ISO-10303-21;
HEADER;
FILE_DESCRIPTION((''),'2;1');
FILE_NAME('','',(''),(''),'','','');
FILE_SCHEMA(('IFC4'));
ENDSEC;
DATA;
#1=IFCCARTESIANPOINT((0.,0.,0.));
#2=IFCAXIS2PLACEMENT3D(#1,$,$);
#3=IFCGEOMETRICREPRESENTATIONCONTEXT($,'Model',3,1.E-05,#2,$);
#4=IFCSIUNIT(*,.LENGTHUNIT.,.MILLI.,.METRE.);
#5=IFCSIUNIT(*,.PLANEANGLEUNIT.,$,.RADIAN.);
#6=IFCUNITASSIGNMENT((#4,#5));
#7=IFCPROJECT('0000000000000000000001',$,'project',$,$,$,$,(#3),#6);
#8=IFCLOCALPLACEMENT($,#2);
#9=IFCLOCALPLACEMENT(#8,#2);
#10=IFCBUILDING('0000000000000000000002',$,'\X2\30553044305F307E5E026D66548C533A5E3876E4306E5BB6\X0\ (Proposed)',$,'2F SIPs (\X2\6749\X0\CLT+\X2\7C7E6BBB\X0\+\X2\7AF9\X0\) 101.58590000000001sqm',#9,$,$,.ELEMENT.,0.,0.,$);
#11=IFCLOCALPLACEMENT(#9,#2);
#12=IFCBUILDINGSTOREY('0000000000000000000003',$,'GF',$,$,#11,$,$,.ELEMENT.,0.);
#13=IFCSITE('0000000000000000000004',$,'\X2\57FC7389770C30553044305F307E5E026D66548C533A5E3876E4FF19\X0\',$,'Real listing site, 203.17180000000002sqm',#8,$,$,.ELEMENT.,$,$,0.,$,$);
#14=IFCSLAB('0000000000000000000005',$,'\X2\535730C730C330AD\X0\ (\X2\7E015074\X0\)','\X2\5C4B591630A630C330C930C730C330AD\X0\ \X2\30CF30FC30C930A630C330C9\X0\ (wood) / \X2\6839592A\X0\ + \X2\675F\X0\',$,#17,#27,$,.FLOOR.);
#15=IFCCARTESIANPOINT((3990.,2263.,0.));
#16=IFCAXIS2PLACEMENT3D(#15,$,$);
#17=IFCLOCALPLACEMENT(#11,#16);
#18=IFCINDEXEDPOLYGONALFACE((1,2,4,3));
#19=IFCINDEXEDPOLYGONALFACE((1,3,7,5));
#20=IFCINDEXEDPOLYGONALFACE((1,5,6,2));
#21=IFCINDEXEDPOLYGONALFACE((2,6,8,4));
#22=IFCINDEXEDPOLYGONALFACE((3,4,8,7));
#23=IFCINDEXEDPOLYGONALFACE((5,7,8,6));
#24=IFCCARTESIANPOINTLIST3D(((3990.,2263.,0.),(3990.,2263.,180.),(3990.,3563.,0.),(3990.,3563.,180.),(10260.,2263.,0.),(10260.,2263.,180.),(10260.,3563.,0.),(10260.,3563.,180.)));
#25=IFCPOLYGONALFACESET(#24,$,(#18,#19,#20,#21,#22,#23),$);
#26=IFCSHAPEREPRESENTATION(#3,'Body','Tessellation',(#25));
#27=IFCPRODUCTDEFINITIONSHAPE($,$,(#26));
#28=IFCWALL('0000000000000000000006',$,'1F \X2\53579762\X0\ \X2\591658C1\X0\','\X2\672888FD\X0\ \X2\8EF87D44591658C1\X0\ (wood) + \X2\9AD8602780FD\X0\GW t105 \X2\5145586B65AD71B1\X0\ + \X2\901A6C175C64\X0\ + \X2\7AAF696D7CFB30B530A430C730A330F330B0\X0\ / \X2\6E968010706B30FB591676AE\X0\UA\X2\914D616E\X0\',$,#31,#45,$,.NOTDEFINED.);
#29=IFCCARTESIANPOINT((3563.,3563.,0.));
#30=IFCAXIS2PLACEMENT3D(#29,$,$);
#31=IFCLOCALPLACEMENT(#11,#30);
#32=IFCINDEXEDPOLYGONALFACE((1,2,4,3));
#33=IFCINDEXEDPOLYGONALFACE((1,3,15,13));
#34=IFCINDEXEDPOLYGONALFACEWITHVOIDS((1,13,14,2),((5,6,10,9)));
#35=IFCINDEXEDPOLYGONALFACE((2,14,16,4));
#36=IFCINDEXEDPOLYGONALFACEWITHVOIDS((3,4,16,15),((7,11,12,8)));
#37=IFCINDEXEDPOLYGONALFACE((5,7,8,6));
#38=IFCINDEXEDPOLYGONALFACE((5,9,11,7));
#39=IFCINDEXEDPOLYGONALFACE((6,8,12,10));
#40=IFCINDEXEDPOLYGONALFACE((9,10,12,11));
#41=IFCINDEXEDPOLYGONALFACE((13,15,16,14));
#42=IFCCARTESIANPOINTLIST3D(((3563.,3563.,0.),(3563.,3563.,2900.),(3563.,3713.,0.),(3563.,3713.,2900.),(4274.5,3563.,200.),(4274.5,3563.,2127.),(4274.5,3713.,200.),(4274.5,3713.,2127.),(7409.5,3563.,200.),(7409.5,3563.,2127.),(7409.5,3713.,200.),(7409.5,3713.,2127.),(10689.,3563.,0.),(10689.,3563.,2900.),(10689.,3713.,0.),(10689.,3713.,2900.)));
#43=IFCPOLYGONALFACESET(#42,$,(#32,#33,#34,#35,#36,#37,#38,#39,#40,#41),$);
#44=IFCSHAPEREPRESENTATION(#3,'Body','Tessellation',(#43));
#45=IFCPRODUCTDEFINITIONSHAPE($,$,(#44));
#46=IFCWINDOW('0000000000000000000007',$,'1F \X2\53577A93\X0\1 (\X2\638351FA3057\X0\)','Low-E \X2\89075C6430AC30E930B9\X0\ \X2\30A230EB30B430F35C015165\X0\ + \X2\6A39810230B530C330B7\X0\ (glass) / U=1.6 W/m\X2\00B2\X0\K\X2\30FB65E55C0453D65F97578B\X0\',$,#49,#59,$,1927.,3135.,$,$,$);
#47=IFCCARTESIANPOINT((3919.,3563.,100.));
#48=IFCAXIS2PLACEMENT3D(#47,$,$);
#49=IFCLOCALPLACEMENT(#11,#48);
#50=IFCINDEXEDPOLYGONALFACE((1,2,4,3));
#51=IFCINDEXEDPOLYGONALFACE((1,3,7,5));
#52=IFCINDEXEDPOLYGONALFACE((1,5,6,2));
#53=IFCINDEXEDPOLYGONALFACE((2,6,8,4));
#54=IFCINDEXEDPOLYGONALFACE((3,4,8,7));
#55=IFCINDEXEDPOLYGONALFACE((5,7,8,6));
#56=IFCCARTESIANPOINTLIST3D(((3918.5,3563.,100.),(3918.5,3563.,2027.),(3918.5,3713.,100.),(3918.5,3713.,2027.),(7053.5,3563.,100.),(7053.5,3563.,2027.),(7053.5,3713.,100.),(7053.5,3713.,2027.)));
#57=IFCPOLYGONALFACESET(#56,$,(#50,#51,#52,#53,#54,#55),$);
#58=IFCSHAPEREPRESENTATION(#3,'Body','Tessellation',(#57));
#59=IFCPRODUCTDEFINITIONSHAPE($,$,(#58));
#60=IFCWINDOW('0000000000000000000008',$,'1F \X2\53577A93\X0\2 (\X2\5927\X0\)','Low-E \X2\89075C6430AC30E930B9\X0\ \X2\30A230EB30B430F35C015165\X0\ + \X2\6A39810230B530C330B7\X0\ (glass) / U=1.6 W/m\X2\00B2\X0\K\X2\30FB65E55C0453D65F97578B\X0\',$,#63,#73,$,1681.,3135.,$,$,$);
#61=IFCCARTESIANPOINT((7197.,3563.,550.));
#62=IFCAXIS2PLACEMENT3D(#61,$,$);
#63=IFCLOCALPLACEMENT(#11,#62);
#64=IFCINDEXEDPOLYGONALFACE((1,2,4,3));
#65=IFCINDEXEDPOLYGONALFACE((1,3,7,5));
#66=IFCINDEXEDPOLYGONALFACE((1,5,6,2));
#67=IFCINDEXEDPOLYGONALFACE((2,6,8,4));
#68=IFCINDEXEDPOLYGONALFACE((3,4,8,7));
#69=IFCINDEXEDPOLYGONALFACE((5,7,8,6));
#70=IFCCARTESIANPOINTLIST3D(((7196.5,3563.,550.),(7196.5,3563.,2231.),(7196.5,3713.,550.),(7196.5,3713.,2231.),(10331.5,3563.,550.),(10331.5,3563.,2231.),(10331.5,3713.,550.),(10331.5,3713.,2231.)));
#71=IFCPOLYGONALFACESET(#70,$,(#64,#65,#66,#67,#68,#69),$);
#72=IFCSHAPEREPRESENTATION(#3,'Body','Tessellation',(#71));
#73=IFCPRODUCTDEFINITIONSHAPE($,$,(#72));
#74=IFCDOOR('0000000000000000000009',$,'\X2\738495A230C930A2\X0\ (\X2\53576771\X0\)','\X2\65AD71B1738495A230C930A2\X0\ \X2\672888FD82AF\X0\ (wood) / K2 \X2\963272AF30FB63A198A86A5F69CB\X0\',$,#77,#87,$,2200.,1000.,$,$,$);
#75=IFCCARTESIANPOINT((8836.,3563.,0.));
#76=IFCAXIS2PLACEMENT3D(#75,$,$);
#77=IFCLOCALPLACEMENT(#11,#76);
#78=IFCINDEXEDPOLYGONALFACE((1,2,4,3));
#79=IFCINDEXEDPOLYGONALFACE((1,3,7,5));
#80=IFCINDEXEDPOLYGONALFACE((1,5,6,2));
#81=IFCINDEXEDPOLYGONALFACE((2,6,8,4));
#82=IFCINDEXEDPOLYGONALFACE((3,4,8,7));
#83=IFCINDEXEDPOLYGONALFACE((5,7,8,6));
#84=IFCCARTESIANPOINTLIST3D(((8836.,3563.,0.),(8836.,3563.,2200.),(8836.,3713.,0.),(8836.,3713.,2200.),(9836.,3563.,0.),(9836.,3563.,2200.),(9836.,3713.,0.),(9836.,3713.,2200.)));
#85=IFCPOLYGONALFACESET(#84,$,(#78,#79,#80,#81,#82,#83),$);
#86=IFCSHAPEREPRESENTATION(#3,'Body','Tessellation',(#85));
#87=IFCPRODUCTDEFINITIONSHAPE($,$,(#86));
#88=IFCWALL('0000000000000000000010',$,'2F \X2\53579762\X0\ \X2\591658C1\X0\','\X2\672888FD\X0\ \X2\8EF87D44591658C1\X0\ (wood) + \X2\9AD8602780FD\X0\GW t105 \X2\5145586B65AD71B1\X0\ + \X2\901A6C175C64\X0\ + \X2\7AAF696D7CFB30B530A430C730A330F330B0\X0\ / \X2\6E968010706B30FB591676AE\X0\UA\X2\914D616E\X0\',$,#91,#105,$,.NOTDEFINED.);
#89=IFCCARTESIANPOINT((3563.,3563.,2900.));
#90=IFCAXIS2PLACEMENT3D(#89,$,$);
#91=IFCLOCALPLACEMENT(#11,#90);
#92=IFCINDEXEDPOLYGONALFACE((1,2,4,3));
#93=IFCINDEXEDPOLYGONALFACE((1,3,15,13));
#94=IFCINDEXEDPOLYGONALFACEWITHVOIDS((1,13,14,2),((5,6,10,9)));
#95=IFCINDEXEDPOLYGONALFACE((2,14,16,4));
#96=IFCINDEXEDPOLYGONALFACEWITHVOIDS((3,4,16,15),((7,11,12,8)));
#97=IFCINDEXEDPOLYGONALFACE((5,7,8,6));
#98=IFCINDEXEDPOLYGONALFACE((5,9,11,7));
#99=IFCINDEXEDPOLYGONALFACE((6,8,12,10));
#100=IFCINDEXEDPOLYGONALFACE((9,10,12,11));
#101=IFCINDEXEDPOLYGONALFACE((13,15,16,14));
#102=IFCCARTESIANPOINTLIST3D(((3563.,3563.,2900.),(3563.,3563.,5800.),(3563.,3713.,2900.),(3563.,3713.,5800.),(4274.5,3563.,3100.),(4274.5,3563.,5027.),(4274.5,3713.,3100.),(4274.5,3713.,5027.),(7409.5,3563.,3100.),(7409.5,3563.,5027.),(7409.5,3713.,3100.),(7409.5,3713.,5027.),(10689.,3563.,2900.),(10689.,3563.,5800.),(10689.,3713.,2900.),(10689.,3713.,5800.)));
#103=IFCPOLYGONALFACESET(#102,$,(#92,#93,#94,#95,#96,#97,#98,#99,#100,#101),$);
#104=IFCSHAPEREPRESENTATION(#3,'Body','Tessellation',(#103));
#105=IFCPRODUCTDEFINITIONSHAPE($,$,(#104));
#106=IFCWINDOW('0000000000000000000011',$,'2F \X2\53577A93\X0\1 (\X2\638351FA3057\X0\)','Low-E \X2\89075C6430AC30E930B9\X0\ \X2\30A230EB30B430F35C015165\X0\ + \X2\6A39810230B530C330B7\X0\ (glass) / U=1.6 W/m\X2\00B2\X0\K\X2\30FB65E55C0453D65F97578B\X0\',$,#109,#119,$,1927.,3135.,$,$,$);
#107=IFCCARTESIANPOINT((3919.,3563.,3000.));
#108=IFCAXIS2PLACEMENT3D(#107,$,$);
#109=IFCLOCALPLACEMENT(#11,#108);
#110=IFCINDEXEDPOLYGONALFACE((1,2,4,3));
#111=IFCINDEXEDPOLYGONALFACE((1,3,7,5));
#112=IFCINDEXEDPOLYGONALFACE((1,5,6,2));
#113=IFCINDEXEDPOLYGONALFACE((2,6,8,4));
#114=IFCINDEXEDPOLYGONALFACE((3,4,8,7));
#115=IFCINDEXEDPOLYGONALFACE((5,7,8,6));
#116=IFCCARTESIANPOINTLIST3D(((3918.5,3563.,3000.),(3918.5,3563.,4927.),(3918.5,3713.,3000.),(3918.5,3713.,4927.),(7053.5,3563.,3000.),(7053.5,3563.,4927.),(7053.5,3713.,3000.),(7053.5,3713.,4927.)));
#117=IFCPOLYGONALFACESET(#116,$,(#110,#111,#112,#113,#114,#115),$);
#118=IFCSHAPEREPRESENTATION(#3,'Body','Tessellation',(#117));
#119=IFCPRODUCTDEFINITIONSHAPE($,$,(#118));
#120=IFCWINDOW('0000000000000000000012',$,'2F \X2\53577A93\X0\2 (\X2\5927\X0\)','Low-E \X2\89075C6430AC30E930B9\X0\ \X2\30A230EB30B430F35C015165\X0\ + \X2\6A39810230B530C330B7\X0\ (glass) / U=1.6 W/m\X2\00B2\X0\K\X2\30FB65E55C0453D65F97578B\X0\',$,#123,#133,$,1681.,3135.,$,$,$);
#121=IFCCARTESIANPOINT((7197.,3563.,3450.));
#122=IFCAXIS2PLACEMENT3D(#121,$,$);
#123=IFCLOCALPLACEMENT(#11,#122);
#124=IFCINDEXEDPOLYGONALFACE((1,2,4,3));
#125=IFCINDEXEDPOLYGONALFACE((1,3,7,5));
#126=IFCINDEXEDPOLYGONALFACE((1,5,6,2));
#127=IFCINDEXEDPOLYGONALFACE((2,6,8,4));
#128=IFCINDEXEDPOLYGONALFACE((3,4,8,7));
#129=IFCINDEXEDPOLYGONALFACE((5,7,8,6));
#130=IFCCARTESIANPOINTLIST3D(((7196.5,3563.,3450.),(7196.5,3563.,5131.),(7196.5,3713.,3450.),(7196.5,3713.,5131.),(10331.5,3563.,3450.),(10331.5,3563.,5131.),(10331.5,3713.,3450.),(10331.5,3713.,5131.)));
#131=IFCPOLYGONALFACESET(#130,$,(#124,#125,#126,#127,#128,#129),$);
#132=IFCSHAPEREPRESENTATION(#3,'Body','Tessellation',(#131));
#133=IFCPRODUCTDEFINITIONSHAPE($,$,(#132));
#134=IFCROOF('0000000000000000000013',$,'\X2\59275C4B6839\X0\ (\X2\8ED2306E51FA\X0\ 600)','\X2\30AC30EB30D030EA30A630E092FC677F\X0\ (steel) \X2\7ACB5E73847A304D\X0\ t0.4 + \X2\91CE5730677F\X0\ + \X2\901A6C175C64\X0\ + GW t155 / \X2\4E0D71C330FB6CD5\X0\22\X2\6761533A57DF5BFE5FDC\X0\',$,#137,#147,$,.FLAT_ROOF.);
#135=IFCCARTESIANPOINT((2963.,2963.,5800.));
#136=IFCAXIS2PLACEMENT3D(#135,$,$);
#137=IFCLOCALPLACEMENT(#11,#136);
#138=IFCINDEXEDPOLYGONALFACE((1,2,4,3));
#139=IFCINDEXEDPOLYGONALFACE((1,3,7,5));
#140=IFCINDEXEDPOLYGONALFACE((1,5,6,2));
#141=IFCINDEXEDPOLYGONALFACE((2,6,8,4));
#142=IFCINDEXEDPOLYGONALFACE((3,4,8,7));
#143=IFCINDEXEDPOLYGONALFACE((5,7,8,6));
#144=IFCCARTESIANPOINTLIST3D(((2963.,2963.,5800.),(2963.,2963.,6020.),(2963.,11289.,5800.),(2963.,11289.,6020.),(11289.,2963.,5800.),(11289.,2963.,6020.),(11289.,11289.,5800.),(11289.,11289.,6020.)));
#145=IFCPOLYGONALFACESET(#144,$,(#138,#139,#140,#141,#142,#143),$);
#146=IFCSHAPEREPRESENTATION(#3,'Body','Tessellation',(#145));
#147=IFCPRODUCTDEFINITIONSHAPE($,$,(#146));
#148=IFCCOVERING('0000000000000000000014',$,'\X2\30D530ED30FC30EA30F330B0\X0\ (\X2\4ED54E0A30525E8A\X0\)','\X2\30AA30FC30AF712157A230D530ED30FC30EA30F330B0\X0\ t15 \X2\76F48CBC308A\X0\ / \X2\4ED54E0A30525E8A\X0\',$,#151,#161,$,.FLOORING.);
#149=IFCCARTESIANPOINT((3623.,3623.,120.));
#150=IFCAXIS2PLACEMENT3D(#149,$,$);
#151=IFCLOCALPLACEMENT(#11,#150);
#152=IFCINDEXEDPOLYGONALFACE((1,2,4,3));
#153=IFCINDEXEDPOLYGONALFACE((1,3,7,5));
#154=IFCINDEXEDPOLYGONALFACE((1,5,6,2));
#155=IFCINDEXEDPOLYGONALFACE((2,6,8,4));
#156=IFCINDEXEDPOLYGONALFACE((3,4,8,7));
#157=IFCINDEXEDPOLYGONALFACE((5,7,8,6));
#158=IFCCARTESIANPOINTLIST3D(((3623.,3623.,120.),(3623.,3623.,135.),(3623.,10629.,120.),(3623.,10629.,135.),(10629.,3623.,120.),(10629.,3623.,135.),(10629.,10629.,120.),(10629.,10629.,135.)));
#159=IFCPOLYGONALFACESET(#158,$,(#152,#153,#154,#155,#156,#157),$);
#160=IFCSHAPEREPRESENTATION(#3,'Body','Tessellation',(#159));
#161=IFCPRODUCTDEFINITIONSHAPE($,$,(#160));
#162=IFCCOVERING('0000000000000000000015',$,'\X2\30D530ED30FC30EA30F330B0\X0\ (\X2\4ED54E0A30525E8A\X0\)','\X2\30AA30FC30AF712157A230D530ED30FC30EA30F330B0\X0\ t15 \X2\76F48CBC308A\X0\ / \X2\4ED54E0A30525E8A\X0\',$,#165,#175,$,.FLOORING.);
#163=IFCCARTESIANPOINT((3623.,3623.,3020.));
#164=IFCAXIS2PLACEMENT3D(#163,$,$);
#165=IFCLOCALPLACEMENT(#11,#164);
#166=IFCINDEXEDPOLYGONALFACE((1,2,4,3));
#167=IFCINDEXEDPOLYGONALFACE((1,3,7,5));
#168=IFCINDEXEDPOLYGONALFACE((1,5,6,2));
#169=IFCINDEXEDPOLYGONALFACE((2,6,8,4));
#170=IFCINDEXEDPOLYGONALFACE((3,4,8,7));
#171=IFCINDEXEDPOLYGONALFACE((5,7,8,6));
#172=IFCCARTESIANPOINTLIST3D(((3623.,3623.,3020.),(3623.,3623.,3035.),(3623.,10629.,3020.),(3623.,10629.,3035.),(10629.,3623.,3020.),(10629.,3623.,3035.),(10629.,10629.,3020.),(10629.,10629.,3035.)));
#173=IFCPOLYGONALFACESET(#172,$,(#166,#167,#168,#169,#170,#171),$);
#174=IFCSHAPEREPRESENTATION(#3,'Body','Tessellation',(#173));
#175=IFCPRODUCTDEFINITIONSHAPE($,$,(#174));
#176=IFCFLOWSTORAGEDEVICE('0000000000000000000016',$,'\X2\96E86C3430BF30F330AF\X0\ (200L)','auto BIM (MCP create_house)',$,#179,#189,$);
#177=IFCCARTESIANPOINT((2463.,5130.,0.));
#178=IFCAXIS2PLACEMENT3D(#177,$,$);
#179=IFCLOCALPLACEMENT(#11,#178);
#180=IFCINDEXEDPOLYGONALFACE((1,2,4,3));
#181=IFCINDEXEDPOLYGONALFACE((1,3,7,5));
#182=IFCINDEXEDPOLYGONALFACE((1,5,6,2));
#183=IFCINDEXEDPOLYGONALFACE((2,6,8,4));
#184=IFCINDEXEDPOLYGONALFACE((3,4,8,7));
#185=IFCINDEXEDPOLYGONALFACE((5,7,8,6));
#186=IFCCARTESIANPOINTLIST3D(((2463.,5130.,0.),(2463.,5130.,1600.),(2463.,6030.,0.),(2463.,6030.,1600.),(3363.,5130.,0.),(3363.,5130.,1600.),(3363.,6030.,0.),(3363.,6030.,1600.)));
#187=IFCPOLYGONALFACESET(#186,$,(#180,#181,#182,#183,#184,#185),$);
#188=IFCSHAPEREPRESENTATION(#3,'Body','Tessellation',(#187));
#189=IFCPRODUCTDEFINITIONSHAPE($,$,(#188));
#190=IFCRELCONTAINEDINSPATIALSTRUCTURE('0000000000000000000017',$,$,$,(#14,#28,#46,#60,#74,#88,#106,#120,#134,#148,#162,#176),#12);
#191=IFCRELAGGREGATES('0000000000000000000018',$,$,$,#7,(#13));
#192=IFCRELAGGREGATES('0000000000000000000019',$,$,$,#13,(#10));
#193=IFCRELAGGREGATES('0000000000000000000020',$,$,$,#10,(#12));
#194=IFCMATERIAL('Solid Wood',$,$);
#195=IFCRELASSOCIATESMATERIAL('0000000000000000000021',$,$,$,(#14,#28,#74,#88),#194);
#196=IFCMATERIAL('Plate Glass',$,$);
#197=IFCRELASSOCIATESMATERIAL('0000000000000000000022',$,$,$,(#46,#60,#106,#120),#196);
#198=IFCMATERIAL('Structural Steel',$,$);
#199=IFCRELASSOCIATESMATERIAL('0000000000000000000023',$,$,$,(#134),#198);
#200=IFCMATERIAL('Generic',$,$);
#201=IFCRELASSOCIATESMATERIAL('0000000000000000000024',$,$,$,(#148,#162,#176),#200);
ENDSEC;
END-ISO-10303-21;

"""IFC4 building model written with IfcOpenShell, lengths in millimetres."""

from ifc_helpers import new_model, si_unit, frame, frame_2d, origin, place, context, project, spatial, rectangle, extrude, material, element, fill, save


model = new_model("IFC4")

# Units and contexts
model_context = context("Model", 3, precision=1e-05, world=origin())
ifc_project = project(units=[si_unit("LENGTHUNIT", "METRE", prefix="MILLI"), si_unit("PLANEANGLEUNIT", "RADIAN")], contexts=[model_context])

# Site, building, storey
site_placement = place(None, origin())
site = spatial("IfcSite", under=ifc_project, at=site_placement, Name="埼玉県さいたま市浦和区常盤９", ObjectType="Real listing site, 203.17180000000002sqm", CompositionType="ELEMENT", RefElevation=0.0)
building_placement = place(site_placement, origin())
building = spatial("IfcBuilding", under=site, at=building_placement, Name="さいたま市浦和区常盤の家 (Proposed)", ObjectType="2F SIPs (杉CLT+籾殻+竹) 101.58590000000001sqm", CompositionType="ELEMENT", ElevationOfRefHeight=0.0, ElevationOfTerrain=0.0)
storey_placement = place(building_placement, origin())
storey = spatial("IfcBuildingStorey", under=building, at=storey_placement, Name="GF", CompositionType="ELEMENT", Elevation=0.0)

# Slab
ifc_material_1 = material(Name="Solid Wood")
slab_1_placement = place(storey_placement, frame((3990.0, 2263.0, 0.0)))
element("IfcSlab", 1, at=slab_1_placement, inside=storey, material=ifc_material_1, Name="南デッキ (縁側)", Description="屋外ウッドデッキ ハードウッド (wood) / 根太 + 束", PredefinedType="FLOOR", context=model_context, shape_type="SweptSolid", body=[
    extrude(rectangle(XDim=6270.0, YDim=1300.0, at=frame_2d((3135.0, 650.0))), frame((3990.0, 2263.0, 0.0)), (0.0, 0.0, 1.0), 180.0),
])

# Wall, openings, windows, door
wall_1_placement = place(storey_placement, frame((3563.0, 3563.0, 0.0)))
wall_1 = element("IfcWall", 2, at=wall_1_placement, inside=storey, material=ifc_material_1, Name="1F 南面 外壁", Description="木製 軸組外壁 (wood) + 高性能GW t105 充填断熱 + 通気層 + 窯業系サイディング / 準耐火・外皮UA配慮", PredefinedType="NOTDEFINED", context=model_context, shape_type="SweptSolid", body=[
    extrude(rectangle(XDim=7126.0, YDim=150.0, at=frame_2d((3563.0, 75.0))), frame((3563.0, 3563.0, 0.0)), (0.0, 0.0, 1.0), 2900.0),
])
opening_1_placement = place(storey_placement, frame((3919.0, 3563.0, 100.0)))
opening_1 = element("IfcOpeningElement", 3, at=opening_1_placement, cuts=wall_1, PredefinedType="NOTDEFINED", context=model_context, shape_type="SweptSolid", body=[
    extrude(rectangle(XDim=3135.0, YDim=150.0, at=frame_2d((1567.0, 75.0))), frame((3919.0, 3563.0, 100.0)), (0.0, 0.0, 1.0), 1927.0),
])
opening_2_placement = place(storey_placement, frame((7197.0, 3563.0, 550.0)))
opening_2 = element("IfcOpeningElement", 4, at=opening_2_placement, cuts=wall_1, PredefinedType="NOTDEFINED", context=model_context, shape_type="SweptSolid", body=[
    extrude(rectangle(XDim=3135.0, YDim=150.0, at=frame_2d((1567.0, 75.0))), frame((7197.0, 3563.0, 550.0)), (0.0, 0.0, 1.0), 1681.0),
])
opening_3_placement = place(storey_placement, frame((8836.0, 3563.0, 0.0)))
opening_3 = element("IfcOpeningElement", 5, at=opening_3_placement, cuts=wall_1, PredefinedType="NOTDEFINED", context=model_context, shape_type="SweptSolid", body=[
    extrude(rectangle(XDim=1000.0, YDim=150.0, at=frame_2d((500.0, 75.0))), frame((8836.0, 3563.0, 0.0)), (0.0, 0.0, 1.0), 2200.0),
])
ifc_material_2 = material(Name="Plate Glass")
window_1_placement = place(storey_placement, frame((3919.0, 3563.0, 100.0)))
window_1 = element("IfcWindow", 6, at=window_1_placement, inside=storey, material=ifc_material_2, Name="1F 南窓1 (掃出し)", Description="Low-E 複層ガラス アルゴン封入 + 樹脂サッシ (glass) / U=1.6 W/m²K・日射取得型", OverallHeight=1927.0, OverallWidth=3135.0, context=model_context, shape_type="SweptSolid", body=[
    extrude(rectangle(XDim=3135.0, YDim=150.0, at=frame_2d((1567.0, 75.0))), frame((3919.0, 3563.0, 100.0)), (0.0, 0.0, 1.0), 1927.0),
])
fill(opening_1, window_1)
window_2_placement = place(storey_placement, frame((7197.0, 3563.0, 550.0)))
window_2 = element("IfcWindow", 7, at=window_2_placement, inside=storey, material=ifc_material_2, Name="1F 南窓2 (大)", Description="Low-E 複層ガラス アルゴン封入 + 樹脂サッシ (glass) / U=1.6 W/m²K・日射取得型", OverallHeight=1681.0, OverallWidth=3135.0, context=model_context, shape_type="SweptSolid", body=[
    extrude(rectangle(XDim=3135.0, YDim=150.0, at=frame_2d((1567.0, 75.0))), frame((7197.0, 3563.0, 550.0)), (0.0, 0.0, 1.0), 1681.0),
])
fill(opening_2, window_2)
door_placement = place(storey_placement, frame((8836.0, 3563.0, 0.0)))
door = element("IfcDoor", 8, at=door_placement, inside=storey, material=ifc_material_1, Name="玄関ドア (南東)", Description="断熱玄関ドア 木製芯 (wood) / K2 防犯・採風機構", OverallHeight=2200.0, OverallWidth=1000.0, context=model_context, shape_type="SweptSolid", body=[
    extrude(rectangle(XDim=1000.0, YDim=150.0, at=frame_2d((500.0, 75.0))), frame((8836.0, 3563.0, 0.0)), (0.0, 0.0, 1.0), 2200.0),
])
fill(opening_3, door)

# Wall, openings, windows
wall_2_placement = place(storey_placement, frame((3563.0, 3563.0, 2900.0)))
wall_2 = element("IfcWall", 9, at=wall_2_placement, inside=storey, material=ifc_material_1, Name="2F 南面 外壁", Description="木製 軸組外壁 (wood) + 高性能GW t105 充填断熱 + 通気層 + 窯業系サイディング / 準耐火・外皮UA配慮", PredefinedType="NOTDEFINED", context=model_context, shape_type="SweptSolid", body=[
    extrude(rectangle(XDim=7126.0, YDim=150.0, at=frame_2d((3563.0, 75.0))), frame((3563.0, 3563.0, 2900.0)), (0.0, 0.0, 1.0), 2900.0),
])
opening_4_placement = place(storey_placement, frame((3919.0, 3563.0, 3000.0)))
opening_4 = element("IfcOpeningElement", 10, at=opening_4_placement, cuts=wall_2, PredefinedType="NOTDEFINED", context=model_context, shape_type="SweptSolid", body=[
    extrude(rectangle(XDim=3135.0, YDim=150.0, at=frame_2d((1567.0, 75.0))), frame((3919.0, 3563.0, 3000.0)), (0.0, 0.0, 1.0), 1927.0),
])
opening_5_placement = place(storey_placement, frame((7197.0, 3563.0, 3450.0)))
opening_5 = element("IfcOpeningElement", 11, at=opening_5_placement, cuts=wall_2, PredefinedType="NOTDEFINED", context=model_context, shape_type="SweptSolid", body=[
    extrude(rectangle(XDim=3135.0, YDim=150.0, at=frame_2d((1567.0, 75.0))), frame((7197.0, 3563.0, 3450.0)), (0.0, 0.0, 1.0), 1681.0),
])
window_3_placement = place(storey_placement, frame((3919.0, 3563.0, 3000.0)))
window_3 = element("IfcWindow", 12, at=window_3_placement, inside=storey, material=ifc_material_2, Name="2F 南窓1 (掃出し)", Description="Low-E 複層ガラス アルゴン封入 + 樹脂サッシ (glass) / U=1.6 W/m²K・日射取得型", OverallHeight=1927.0, OverallWidth=3135.0, context=model_context, shape_type="SweptSolid", body=[
    extrude(rectangle(XDim=3135.0, YDim=150.0, at=frame_2d((1567.0, 75.0))), frame((3919.0, 3563.0, 3000.0)), (0.0, 0.0, 1.0), 1927.0),
])
fill(opening_4, window_3)
window_4_placement = place(storey_placement, frame((7197.0, 3563.0, 3450.0)))
window_4 = element("IfcWindow", 13, at=window_4_placement, inside=storey, material=ifc_material_2, Name="2F 南窓2 (大)", Description="Low-E 複層ガラス アルゴン封入 + 樹脂サッシ (glass) / U=1.6 W/m²K・日射取得型", OverallHeight=1681.0, OverallWidth=3135.0, context=model_context, shape_type="SweptSolid", body=[
    extrude(rectangle(XDim=3135.0, YDim=150.0, at=frame_2d((1567.0, 75.0))), frame((7197.0, 3563.0, 3450.0)), (0.0, 0.0, 1.0), 1681.0),
])
fill(opening_5, window_4)

# Roof
ifc_material_3 = material(Name="Structural Steel")
roof_placement = place(storey_placement, frame((2963.0, 2963.0, 5800.0)))
element("IfcRoof", 14, at=roof_placement, inside=storey, material=ifc_material_3, Name="大屋根 (軒の出 600)", Description="ガルバリウム鋼板 (steel) 立平葺き t0.4 + 野地板 + 通気層 + GW t155 / 不燃・法22条区域対応", PredefinedType="FLAT_ROOF", context=model_context, shape_type="SweptSolid", body=[
    extrude(rectangle(XDim=8326.0, YDim=8326.0, at=frame_2d((4163.0, 4163.0))), frame((2963.0, 2963.0, 5800.0)), (0.0, 0.0, 1.0), 220.0),
])

# Coverings
ifc_material_4 = material(Name="Generic")
covering_1_placement = place(storey_placement, frame((3623.0, 3623.0, 120.0)))
element("IfcCovering", 15, at=covering_1_placement, inside=storey, material=ifc_material_4, Name="フローリング (仕上げ床)", Description="オーク無垢フローリング t15 直貼り / 仕上げ床", PredefinedType="FLOORING", context=model_context, shape_type="SweptSolid", body=[
    extrude(rectangle(XDim=7006.0, YDim=7006.0, at=frame_2d((3503.0, 3503.0))), frame((3623.0, 3623.0, 120.0)), (0.0, 0.0, 1.0), 15.0),
])
covering_2_placement = place(storey_placement, frame((3623.0, 3623.0, 3020.0)))
element("IfcCovering", 16, at=covering_2_placement, inside=storey, material=ifc_material_4, Name="フローリング (仕上げ床)", Description="オーク無垢フローリング t15 直貼り / 仕上げ床", PredefinedType="FLOORING", context=model_context, shape_type="SweptSolid", body=[
    extrude(rectangle(XDim=7006.0, YDim=7006.0, at=frame_2d((3503.0, 3503.0))), frame((3623.0, 3623.0, 3020.0)), (0.0, 0.0, 1.0), 15.0),
])

# Flow storage device
flow_storage_device_placement = place(storey_placement, frame((2463.0, 5130.0, 0.0)))
element("IfcFlowStorageDevice", 17, at=flow_storage_device_placement, inside=storey, material=ifc_material_4, Name="雨水タンク (200L)", Description="auto BIM (MCP create_house)", context=model_context, shape_type="SweptSolid", body=[
    extrude(rectangle(XDim=900.0, YDim=900.0, at=frame_2d((450.0, 450.0))), frame((2463.0, 5130.0, 0.0)), (0.0, 0.0, 1.0), 1600.0),
])

save(model, "model.ifc")
